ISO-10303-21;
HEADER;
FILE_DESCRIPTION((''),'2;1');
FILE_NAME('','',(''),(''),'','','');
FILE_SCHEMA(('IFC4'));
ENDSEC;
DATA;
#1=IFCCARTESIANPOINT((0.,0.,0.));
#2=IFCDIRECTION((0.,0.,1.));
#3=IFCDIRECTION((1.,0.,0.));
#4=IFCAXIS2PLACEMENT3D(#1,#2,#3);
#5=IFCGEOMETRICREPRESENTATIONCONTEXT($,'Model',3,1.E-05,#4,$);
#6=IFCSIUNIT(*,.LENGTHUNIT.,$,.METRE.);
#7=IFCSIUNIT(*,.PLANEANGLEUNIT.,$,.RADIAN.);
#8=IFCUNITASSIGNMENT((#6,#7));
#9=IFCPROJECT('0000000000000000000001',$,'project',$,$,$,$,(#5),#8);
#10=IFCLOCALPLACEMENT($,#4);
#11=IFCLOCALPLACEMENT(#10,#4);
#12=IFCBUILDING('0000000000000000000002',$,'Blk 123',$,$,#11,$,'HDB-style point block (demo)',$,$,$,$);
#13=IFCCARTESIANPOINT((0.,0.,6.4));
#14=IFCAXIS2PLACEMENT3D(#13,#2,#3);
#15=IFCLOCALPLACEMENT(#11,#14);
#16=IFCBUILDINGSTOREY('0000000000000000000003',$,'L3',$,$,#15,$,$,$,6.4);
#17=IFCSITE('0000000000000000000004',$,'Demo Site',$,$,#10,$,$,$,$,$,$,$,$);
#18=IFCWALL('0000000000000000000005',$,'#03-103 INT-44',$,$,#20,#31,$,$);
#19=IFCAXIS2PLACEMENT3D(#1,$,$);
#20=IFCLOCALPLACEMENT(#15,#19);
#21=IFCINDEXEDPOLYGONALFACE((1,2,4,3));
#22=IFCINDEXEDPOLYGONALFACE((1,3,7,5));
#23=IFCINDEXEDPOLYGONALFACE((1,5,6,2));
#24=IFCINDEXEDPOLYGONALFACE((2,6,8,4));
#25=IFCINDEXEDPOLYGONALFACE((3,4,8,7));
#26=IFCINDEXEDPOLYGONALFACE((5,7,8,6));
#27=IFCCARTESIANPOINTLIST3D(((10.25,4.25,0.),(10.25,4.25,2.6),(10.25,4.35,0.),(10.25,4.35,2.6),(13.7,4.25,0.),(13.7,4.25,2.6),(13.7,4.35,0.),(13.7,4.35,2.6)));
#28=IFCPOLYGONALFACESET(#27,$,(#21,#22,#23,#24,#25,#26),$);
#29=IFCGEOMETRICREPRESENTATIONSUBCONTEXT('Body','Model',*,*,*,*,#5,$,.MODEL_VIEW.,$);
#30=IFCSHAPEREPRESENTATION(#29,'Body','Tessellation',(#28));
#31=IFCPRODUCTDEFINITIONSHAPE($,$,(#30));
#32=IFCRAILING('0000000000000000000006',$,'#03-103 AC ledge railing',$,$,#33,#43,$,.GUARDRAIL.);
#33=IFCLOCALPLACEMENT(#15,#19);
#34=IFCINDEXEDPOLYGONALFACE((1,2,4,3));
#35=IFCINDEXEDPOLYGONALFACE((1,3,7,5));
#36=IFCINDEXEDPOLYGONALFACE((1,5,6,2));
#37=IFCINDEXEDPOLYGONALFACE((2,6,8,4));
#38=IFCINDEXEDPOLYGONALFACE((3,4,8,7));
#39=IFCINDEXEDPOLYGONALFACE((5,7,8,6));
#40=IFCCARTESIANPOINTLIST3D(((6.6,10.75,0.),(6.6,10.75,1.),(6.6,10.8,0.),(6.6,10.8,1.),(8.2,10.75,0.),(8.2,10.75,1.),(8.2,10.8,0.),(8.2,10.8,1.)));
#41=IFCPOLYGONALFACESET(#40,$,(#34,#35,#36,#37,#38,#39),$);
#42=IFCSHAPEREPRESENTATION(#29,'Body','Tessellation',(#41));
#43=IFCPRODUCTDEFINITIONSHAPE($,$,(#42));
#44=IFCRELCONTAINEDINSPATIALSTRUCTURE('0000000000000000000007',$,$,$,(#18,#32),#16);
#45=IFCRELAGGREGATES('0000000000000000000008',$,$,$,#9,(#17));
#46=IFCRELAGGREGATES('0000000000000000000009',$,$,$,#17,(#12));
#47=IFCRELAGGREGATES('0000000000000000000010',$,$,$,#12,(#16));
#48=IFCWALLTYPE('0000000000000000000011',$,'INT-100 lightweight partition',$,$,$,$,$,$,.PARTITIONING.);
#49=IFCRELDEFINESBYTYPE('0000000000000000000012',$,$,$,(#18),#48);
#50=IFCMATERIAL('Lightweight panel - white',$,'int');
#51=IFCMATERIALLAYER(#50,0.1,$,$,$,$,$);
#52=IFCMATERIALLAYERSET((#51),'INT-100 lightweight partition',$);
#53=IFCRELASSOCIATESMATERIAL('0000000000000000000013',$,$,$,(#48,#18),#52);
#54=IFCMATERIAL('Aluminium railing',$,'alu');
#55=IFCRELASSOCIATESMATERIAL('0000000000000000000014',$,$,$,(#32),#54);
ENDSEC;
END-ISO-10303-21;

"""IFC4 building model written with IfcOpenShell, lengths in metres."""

from ifc_helpers import new_model, si_unit, frame, origin, origin_with_axes, place, context, subcontext, project, spatial, polyline, indexed_curve, outline, extrude, material, layer, layer_set, layer_usage, type_object, element, save


model = new_model("IFC4")

# Units and contexts
model_context = context("Model", 3, precision=1e-05, world=origin_with_axes())
body_context = subcontext(model_context, "Body", "Model", "MODEL_VIEW")
ifc_project = project(units=[si_unit("LENGTHUNIT", "METRE"), si_unit("PLANEANGLEUNIT", "RADIAN")], contexts=[model_context])

# Site, building, storey
site_placement = place(None, origin_with_axes())
site = spatial("IfcSite", under=ifc_project, at=site_placement, Name="Demo Site")
building_placement = place(site_placement, origin_with_axes())
building = spatial("IfcBuilding", under=site, at=building_placement, Name="Blk 123", LongName="HDB-style point block (demo)")
storey_placement = place(building_placement, frame((0.0, 0.0, 6.4), z_axis=(0.0, 0.0, 1.0), x_axis=(1.0, 0.0, 0.0)))
storey = spatial("IfcBuildingStorey", under=building, at=storey_placement, Name="L3", Elevation=6.4)

# Wall
ifc_material_1 = material(Name="Lightweight panel - white", Category="int")
ifc_layer_1 = layer(ifc_material_1, 0.1)
ifc_layer_set_1 = layer_set([ifc_layer_1], Name="INT-100 lightweight partition")
ifc_layer_usage_1 = layer_usage(ifc_layer_set_1, "AXIS2", "POSITIVE", -0.05)
wall_type_1 = type_object("IfcWallType", Name="INT-100 lightweight partition", PredefinedType="PARTITIONING", material=ifc_layer_set_1)
wall_1_placement = place(storey_placement, frame((10.25, 4.3, 0.0), z_axis=(0.0, 0.0, 1.0), x_axis=(1.0, 0.0, 0.0)))
element("IfcWall", 1, at=wall_1_placement, inside=storey, type_object=wall_type_1, material=ifc_layer_usage_1, Name="#03-103 INT-44", context=body_context, shape_type="SweptSolid", body=[
    extrude(outline(indexed_curve([(0.0, 0.0), (0.0, 0.1), (3.45, 0.1), (3.45, 0.0), (0.0, 0.0)], self_intersect=False)), frame((0.0, -0.05, 0.0), z_axis=(0.0, 0.0, 1.0), x_axis=(1.0, 0.0, 0.0)), (0.0, 0.0, 1.0), 2.6),
])

# Railing
ifc_material_2 = material(Name="Aluminium railing", Category="alu")
railing_placement = place(storey_placement, frame((7.4, 10.775, 0.0), z_axis=(0.0, 0.0, 1.0), x_axis=(1.0, 0.0, 0.0)))
element("IfcRailing", 2, at=railing_placement, inside=storey, material=ifc_material_2, Name="#03-103 AC ledge railing", PredefinedType="GUARDRAIL", context=body_context, shape_type="SweptSolid", body=[
    extrude(outline(polyline([(0.8, -0.025), (0.8, 0.025), (-0.8, 0.025), (-0.8, -0.025), (0.8, -0.025)])), origin(), (0.0, 0.0, 1.0), 1.0),
])

save(model, "model.ifc")
